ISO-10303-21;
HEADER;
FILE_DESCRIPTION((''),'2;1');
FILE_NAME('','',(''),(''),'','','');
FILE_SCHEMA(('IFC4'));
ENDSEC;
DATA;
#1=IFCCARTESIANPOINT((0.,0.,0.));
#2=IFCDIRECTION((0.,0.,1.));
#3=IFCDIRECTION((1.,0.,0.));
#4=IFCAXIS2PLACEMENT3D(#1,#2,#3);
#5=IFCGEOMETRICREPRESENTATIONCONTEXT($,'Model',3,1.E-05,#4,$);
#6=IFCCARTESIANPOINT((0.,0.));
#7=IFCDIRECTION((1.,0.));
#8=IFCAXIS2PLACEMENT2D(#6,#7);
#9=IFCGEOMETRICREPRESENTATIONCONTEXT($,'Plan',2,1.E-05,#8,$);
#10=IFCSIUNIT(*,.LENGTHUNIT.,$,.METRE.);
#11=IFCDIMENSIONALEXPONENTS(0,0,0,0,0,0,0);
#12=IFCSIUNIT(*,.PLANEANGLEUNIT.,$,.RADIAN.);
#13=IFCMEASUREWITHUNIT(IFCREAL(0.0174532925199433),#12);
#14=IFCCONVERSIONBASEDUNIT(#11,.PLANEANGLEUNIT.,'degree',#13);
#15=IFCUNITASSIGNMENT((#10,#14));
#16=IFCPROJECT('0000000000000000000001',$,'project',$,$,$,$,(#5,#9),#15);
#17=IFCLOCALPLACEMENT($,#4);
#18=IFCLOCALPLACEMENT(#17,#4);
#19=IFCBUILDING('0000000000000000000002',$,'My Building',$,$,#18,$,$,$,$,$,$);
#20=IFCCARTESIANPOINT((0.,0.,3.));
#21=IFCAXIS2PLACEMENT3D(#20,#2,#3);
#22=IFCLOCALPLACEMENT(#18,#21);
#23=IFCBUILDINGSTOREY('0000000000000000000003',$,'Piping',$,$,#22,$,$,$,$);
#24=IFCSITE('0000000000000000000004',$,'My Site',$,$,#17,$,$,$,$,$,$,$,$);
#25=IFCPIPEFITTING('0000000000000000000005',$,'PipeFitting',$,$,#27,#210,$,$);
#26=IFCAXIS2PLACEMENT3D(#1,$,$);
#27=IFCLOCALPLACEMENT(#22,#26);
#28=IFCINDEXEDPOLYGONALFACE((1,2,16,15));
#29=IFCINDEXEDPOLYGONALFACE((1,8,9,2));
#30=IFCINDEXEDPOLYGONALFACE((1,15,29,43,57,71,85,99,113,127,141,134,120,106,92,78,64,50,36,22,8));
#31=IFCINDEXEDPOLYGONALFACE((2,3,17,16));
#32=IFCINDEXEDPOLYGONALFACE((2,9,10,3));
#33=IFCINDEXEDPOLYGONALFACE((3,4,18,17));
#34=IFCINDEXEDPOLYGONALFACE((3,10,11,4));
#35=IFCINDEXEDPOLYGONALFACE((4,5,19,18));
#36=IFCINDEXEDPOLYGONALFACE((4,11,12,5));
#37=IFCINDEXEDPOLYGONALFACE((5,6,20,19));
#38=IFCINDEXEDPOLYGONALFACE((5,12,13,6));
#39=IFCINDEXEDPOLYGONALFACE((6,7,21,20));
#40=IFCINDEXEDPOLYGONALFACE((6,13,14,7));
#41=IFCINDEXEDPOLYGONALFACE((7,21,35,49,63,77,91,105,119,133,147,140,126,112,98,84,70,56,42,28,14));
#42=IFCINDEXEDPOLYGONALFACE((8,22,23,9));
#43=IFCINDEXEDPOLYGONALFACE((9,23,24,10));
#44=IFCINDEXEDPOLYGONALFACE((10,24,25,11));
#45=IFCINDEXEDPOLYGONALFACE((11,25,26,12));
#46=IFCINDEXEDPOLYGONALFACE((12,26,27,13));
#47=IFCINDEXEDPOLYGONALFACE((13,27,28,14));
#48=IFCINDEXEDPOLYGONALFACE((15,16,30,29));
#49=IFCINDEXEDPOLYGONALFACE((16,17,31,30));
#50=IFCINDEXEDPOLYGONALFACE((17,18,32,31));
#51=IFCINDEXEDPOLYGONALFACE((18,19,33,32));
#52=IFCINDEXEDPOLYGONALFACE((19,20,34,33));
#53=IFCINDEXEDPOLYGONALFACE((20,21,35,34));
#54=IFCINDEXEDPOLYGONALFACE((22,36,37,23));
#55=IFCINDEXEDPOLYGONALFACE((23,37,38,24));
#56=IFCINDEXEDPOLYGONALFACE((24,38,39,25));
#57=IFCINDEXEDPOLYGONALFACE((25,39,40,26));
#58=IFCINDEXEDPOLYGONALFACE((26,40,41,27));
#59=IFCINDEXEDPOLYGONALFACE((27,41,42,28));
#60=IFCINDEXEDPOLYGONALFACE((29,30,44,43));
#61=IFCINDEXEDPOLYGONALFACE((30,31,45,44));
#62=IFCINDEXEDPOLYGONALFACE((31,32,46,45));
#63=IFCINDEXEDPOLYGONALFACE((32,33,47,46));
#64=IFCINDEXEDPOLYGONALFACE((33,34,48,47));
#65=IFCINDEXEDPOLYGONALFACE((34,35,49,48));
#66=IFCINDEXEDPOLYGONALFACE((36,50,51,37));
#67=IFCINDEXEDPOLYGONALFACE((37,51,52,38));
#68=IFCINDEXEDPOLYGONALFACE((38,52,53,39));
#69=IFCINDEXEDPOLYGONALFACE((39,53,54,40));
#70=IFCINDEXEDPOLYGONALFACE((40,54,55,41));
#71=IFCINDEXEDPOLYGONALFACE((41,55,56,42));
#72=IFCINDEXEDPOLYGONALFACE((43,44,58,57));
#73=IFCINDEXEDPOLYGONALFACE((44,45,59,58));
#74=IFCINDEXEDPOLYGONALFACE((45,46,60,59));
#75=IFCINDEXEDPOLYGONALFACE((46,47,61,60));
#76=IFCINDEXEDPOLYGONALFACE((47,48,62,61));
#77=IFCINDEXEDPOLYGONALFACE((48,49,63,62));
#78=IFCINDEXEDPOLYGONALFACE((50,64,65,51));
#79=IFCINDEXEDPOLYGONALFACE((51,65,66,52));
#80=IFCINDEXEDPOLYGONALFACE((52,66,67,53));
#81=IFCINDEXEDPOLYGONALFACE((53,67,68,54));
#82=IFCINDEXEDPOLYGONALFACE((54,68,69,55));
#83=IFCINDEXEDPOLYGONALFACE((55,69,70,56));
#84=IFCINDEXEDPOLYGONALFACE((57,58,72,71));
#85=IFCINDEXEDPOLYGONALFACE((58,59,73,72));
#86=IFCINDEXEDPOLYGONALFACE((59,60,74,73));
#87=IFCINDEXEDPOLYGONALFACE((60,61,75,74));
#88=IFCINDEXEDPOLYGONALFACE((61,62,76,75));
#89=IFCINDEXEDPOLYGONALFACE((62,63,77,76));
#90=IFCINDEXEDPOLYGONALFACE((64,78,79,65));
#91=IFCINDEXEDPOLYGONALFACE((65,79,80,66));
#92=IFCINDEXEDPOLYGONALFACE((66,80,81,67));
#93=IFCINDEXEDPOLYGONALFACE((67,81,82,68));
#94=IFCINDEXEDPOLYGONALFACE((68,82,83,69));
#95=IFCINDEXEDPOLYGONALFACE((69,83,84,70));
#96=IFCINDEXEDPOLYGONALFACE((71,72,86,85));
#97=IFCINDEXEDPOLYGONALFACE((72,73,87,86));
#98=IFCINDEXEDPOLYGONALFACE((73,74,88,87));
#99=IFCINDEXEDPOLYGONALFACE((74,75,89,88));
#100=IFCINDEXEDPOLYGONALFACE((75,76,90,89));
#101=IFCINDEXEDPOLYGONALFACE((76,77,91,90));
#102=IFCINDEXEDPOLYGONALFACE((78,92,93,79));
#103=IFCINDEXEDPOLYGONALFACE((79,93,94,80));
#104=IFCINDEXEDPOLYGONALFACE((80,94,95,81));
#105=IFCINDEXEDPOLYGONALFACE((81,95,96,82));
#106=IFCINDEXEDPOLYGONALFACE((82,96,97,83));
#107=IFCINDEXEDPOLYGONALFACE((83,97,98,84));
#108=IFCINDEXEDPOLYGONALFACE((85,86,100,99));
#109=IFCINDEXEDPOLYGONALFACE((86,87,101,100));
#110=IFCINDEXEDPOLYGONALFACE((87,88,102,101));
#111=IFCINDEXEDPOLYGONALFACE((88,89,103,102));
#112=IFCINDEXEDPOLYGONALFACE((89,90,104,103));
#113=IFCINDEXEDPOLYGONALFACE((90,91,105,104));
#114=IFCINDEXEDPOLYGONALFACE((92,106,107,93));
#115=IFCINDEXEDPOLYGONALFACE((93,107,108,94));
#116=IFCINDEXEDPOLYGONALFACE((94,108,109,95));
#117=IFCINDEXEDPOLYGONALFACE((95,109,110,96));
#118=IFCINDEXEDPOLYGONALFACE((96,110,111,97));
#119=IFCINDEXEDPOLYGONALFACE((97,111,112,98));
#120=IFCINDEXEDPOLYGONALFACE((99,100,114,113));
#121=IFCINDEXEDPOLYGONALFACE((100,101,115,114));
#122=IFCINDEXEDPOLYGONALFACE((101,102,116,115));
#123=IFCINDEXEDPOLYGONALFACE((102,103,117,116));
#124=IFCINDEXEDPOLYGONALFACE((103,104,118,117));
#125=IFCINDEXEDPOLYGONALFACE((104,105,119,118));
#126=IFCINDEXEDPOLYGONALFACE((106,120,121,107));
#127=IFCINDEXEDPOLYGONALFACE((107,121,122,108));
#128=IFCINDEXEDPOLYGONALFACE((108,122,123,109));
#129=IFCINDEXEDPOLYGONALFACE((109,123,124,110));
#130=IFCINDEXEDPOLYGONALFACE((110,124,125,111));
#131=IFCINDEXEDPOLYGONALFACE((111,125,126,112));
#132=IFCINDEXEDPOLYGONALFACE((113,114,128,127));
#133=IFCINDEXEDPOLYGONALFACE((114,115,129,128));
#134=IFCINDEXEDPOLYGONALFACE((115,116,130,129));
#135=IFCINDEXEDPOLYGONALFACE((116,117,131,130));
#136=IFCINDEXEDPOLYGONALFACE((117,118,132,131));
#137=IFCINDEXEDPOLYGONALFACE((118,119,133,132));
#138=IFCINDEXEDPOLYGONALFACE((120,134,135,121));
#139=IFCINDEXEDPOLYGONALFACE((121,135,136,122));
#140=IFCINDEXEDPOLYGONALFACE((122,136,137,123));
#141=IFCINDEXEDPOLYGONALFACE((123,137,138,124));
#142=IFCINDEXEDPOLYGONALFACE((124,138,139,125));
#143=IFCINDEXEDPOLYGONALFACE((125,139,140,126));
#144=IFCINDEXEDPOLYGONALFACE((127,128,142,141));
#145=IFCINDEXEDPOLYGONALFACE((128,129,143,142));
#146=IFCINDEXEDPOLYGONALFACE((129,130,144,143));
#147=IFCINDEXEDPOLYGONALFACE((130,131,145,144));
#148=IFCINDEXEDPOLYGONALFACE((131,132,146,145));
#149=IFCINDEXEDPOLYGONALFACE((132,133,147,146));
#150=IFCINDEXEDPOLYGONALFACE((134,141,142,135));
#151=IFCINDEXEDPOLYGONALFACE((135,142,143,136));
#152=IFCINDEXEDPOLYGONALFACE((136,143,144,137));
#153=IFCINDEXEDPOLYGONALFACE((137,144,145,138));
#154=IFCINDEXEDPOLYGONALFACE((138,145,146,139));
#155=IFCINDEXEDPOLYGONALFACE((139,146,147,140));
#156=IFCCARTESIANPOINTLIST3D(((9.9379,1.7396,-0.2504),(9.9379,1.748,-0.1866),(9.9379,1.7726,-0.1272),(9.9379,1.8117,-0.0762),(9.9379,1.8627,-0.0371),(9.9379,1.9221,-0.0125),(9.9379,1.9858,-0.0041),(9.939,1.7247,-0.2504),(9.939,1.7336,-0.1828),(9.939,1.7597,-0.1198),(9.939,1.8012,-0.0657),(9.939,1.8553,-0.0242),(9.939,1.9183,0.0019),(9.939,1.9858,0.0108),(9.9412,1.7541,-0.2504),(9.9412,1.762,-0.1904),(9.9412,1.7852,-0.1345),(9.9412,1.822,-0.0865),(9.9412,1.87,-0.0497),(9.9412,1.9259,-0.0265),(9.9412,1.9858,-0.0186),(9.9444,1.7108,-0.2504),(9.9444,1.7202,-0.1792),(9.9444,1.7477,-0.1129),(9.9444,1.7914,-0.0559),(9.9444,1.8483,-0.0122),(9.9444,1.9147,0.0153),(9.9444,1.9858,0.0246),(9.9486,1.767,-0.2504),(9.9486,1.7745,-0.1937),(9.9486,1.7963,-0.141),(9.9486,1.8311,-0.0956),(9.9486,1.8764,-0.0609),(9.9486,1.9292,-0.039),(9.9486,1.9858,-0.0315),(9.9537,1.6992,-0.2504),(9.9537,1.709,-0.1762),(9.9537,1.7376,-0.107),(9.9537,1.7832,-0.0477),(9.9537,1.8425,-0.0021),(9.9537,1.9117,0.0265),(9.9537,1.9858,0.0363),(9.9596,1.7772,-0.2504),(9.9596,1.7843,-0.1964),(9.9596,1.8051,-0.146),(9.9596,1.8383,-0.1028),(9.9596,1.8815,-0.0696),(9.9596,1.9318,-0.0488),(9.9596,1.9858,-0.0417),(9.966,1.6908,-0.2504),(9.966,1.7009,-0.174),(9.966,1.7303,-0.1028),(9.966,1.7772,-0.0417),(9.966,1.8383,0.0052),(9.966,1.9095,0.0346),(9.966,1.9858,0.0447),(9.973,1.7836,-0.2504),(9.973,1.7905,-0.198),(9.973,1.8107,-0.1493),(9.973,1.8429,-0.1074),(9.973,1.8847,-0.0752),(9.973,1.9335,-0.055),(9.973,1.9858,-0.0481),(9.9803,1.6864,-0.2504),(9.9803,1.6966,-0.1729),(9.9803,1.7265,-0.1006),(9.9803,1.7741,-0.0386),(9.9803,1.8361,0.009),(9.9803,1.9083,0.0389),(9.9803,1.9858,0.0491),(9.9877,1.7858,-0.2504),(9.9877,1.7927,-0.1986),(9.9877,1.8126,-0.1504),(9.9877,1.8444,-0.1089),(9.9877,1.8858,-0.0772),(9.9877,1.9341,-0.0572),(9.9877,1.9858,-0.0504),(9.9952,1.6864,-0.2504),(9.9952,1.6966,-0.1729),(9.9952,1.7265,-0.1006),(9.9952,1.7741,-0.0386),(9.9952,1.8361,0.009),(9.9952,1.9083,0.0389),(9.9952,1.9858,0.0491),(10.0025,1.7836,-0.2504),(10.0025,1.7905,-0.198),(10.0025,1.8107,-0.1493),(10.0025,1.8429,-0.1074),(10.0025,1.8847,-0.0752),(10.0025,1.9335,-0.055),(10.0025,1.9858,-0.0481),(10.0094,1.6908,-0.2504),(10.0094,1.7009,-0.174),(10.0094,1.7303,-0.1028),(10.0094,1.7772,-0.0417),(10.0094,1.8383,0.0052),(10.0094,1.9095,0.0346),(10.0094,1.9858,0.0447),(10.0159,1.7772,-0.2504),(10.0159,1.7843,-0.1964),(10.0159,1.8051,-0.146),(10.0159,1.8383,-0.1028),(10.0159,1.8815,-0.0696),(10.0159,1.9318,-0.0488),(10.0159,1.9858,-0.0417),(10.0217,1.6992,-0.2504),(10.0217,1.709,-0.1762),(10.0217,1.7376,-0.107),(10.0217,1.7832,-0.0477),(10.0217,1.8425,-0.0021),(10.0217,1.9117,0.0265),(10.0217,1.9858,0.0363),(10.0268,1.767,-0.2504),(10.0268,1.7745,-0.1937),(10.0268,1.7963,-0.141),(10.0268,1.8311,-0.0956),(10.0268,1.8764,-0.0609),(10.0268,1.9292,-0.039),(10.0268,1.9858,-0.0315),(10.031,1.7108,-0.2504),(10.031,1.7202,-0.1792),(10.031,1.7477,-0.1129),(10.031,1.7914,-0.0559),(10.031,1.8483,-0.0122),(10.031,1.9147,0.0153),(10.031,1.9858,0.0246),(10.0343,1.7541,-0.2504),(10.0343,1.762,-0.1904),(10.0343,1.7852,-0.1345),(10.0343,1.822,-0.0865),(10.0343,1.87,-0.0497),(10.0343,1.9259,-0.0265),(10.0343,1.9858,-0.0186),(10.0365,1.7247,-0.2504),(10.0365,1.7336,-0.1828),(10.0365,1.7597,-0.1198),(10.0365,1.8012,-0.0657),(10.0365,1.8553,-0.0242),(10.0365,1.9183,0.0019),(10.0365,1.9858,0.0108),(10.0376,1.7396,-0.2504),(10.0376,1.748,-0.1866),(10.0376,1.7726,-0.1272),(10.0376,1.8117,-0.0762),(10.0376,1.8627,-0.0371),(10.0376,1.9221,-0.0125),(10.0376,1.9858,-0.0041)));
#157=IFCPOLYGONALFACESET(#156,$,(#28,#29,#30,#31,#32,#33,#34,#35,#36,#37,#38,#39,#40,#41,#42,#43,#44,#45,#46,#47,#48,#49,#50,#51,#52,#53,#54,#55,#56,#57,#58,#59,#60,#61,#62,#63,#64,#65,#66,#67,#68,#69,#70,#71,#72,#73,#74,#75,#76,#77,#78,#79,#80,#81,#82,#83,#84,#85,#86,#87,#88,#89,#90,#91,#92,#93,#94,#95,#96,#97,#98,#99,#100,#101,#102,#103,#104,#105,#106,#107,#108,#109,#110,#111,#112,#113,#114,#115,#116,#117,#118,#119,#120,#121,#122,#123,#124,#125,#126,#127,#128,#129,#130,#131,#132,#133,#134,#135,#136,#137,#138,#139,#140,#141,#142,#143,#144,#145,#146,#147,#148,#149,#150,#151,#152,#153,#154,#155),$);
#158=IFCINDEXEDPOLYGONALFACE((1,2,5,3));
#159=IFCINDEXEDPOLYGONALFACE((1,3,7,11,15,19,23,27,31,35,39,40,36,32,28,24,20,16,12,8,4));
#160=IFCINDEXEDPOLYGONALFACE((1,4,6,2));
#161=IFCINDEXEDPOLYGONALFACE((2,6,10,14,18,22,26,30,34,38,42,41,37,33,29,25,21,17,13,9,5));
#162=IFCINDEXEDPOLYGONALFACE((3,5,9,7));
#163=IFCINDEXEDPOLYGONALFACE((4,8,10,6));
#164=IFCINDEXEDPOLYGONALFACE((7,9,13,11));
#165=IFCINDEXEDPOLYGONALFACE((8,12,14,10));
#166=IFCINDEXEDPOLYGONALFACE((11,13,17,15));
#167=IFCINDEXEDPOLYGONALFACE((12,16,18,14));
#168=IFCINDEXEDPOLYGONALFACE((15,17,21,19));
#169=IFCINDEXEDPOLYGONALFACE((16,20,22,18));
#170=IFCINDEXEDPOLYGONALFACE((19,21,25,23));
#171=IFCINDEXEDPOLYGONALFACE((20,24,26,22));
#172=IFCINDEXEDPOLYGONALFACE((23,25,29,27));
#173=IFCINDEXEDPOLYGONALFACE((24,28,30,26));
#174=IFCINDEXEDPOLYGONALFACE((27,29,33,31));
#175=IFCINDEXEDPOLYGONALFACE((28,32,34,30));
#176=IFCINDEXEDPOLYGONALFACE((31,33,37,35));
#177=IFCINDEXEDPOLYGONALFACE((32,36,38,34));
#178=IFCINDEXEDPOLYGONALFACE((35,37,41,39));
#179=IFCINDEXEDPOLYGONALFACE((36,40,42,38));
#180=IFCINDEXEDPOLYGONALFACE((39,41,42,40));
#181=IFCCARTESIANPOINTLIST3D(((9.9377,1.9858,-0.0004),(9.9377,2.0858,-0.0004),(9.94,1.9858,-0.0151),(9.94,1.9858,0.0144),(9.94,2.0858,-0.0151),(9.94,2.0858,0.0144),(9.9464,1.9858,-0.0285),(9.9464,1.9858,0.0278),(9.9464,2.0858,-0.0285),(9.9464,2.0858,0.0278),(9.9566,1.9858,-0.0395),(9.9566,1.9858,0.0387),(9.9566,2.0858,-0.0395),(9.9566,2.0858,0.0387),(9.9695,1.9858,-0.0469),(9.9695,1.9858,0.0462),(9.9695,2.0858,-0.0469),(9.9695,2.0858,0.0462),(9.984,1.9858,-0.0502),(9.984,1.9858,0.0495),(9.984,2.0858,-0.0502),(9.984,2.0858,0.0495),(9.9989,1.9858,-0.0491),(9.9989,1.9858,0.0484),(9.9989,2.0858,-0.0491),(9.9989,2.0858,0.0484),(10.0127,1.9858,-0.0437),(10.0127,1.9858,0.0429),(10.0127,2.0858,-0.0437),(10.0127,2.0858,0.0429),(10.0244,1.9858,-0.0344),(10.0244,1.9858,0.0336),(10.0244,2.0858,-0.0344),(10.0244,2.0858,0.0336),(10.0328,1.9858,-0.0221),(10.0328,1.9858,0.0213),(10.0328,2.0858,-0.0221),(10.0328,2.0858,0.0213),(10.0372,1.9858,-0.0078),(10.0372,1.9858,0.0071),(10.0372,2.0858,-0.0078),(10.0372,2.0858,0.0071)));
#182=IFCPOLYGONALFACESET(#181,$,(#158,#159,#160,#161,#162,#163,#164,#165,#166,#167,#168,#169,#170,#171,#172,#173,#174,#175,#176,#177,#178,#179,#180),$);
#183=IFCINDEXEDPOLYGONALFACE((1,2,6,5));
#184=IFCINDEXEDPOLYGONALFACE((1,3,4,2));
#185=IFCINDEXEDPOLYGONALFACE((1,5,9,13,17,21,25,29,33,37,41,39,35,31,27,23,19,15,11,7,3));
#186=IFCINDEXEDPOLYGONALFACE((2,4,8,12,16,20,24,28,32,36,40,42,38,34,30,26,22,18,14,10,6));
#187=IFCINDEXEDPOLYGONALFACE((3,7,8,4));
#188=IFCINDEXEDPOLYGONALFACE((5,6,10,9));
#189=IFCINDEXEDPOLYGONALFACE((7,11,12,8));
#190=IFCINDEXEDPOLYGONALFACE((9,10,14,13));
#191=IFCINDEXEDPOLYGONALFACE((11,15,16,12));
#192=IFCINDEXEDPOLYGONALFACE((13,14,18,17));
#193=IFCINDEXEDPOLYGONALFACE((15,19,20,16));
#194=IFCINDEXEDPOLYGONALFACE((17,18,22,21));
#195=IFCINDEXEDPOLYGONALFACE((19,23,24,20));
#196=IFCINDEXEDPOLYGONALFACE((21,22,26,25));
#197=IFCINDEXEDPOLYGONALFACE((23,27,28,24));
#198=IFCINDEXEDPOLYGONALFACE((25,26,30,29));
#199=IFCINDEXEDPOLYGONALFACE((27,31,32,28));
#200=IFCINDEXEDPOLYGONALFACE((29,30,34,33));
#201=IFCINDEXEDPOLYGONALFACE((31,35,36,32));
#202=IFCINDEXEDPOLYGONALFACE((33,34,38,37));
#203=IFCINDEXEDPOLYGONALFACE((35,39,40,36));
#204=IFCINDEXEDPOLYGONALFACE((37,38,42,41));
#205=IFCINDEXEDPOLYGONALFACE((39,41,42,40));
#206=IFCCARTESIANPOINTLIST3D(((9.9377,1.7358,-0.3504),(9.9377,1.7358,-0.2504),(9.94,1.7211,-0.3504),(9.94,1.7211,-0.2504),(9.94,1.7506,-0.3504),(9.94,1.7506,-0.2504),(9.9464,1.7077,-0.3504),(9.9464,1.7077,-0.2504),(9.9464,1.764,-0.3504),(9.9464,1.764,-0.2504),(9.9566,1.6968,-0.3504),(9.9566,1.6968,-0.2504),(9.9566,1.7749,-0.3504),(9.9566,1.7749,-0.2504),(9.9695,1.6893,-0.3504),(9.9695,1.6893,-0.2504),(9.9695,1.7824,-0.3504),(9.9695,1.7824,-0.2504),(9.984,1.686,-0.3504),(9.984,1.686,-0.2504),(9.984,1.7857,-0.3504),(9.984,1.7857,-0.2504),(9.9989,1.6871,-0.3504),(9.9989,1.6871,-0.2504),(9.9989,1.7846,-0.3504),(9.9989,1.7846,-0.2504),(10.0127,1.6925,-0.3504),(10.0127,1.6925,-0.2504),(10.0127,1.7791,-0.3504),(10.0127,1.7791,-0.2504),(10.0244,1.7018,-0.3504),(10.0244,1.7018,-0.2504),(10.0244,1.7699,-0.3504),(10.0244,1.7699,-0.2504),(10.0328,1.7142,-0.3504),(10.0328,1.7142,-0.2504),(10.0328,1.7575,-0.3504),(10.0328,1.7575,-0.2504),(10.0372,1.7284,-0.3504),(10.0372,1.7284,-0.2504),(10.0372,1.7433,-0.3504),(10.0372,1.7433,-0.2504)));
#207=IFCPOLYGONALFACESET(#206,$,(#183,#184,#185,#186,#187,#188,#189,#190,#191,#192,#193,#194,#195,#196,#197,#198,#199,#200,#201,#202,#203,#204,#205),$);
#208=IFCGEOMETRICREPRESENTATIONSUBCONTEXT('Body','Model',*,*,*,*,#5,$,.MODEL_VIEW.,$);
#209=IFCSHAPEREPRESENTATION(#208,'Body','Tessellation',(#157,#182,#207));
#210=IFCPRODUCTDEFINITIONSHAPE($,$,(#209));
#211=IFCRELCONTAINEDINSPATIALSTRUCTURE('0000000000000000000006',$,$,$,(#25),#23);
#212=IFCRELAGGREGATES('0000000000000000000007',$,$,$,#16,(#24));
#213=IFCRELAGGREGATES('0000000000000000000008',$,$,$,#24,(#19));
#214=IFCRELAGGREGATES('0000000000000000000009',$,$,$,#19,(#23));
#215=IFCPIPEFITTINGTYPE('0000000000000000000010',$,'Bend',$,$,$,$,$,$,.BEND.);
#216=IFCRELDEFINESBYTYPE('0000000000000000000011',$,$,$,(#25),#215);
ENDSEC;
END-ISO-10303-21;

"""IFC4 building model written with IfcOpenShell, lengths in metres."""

from ifc_helpers import new_model, entity, si_unit, converted_unit, frame, origin_with_axes, origin_2d_with_axis, place, context, subcontext, project, spatial, circle, extrude, source, transform, mapped, type_object, type_shapes, element, save


model = new_model("IFC4")

# Units and contexts
model_context = context("Model", 3, precision=1e-05, world=origin_with_axes())
plan_context = context("Plan", 2, precision=1e-05, world=origin_2d_with_axis())
body_context = subcontext(model_context, "Body", "Model", "MODEL_VIEW")
ifc_project = project(units=[si_unit("LENGTHUNIT", "METRE"), converted_unit("PLANEANGLEUNIT", "degree", entity("IfcReal", 0.0174532925199433), si_unit("PLANEANGLEUNIT", "RADIAN"), dimensions=[0, 0, 0, 0, 0, 0, 0])], contexts=[model_context, plan_context])

# Site, building, storey
site_placement = place(None, origin_with_axes())
site = spatial("IfcSite", under=ifc_project, at=site_placement, Name="My Site")
building_placement = place(site_placement, origin_with_axes())
building = spatial("IfcBuilding", under=site, at=building_placement, Name="My Building")
storey_placement = place(building_placement, frame((0.0, 0.0, 3.0), z_axis=(0.0, 0.0, 1.0), x_axis=(1.0, 0.0, 0.0)))
storey = spatial("IfcBuildingStorey", under=building, at=storey_placement, Name="Piping")

# Shared definitions
pipe_fitting_type = type_object("IfcPipeFittingType", Name="Bend", PredefinedType="BEND")
shared_shape = source(origin_with_axes(), body_context, "Body", "SolidModel", [
    entity("IfcSweptDiskSolid", entity("IfcIndexedPolyCurve", entity("IfcCartesianPointList3D", [[0.0, 0.0, -0.1], [0.0, -0.0732, -0.2768], [0.0, -0.25, -0.35]]), [entity("IfcArcIndex", [1, 2, 3])]), 0.05),
    extrude(circle(Radius=0.05), origin_with_axes(), (0.0, 0.0, -1.0), 0.1),
    extrude(circle(Radius=0.05), frame((0.0, -0.25, -0.35), z_axis=(0.0, -1.0, 0.0), x_axis=(1.0, 0.0, 0.0)), (0.0, 0.0, 1.0), 0.1),
])
type_shapes(pipe_fitting_type, [shared_shape])

# Pipe fitting
for number, where, z_axis, x_axis, name in (
    (1, (9.9877, 2.0858, -0.0004), (0.0, 1.0, 0.0), (-1.0, 0.0, 0.0), "PipeFitting"),
):
    element("IfcPipeFitting", number, at=place(storey_placement, frame(where, z_axis=z_axis, x_axis=x_axis)), inside=storey, type_object=pipe_fitting_type, Name=name, context=body_context, shape_type="MappedRepresentation", body=[
        mapped(shared_shape, transform((0.0, 0.0, 0.0), x_axis=(1.0, 0.0, 0.0), y_axis=(0.0, 1.0, 0.0), z_axis=(0.0, 0.0, 1.0), scale=1.0)),
    ])

save(model, "model.ifc")
